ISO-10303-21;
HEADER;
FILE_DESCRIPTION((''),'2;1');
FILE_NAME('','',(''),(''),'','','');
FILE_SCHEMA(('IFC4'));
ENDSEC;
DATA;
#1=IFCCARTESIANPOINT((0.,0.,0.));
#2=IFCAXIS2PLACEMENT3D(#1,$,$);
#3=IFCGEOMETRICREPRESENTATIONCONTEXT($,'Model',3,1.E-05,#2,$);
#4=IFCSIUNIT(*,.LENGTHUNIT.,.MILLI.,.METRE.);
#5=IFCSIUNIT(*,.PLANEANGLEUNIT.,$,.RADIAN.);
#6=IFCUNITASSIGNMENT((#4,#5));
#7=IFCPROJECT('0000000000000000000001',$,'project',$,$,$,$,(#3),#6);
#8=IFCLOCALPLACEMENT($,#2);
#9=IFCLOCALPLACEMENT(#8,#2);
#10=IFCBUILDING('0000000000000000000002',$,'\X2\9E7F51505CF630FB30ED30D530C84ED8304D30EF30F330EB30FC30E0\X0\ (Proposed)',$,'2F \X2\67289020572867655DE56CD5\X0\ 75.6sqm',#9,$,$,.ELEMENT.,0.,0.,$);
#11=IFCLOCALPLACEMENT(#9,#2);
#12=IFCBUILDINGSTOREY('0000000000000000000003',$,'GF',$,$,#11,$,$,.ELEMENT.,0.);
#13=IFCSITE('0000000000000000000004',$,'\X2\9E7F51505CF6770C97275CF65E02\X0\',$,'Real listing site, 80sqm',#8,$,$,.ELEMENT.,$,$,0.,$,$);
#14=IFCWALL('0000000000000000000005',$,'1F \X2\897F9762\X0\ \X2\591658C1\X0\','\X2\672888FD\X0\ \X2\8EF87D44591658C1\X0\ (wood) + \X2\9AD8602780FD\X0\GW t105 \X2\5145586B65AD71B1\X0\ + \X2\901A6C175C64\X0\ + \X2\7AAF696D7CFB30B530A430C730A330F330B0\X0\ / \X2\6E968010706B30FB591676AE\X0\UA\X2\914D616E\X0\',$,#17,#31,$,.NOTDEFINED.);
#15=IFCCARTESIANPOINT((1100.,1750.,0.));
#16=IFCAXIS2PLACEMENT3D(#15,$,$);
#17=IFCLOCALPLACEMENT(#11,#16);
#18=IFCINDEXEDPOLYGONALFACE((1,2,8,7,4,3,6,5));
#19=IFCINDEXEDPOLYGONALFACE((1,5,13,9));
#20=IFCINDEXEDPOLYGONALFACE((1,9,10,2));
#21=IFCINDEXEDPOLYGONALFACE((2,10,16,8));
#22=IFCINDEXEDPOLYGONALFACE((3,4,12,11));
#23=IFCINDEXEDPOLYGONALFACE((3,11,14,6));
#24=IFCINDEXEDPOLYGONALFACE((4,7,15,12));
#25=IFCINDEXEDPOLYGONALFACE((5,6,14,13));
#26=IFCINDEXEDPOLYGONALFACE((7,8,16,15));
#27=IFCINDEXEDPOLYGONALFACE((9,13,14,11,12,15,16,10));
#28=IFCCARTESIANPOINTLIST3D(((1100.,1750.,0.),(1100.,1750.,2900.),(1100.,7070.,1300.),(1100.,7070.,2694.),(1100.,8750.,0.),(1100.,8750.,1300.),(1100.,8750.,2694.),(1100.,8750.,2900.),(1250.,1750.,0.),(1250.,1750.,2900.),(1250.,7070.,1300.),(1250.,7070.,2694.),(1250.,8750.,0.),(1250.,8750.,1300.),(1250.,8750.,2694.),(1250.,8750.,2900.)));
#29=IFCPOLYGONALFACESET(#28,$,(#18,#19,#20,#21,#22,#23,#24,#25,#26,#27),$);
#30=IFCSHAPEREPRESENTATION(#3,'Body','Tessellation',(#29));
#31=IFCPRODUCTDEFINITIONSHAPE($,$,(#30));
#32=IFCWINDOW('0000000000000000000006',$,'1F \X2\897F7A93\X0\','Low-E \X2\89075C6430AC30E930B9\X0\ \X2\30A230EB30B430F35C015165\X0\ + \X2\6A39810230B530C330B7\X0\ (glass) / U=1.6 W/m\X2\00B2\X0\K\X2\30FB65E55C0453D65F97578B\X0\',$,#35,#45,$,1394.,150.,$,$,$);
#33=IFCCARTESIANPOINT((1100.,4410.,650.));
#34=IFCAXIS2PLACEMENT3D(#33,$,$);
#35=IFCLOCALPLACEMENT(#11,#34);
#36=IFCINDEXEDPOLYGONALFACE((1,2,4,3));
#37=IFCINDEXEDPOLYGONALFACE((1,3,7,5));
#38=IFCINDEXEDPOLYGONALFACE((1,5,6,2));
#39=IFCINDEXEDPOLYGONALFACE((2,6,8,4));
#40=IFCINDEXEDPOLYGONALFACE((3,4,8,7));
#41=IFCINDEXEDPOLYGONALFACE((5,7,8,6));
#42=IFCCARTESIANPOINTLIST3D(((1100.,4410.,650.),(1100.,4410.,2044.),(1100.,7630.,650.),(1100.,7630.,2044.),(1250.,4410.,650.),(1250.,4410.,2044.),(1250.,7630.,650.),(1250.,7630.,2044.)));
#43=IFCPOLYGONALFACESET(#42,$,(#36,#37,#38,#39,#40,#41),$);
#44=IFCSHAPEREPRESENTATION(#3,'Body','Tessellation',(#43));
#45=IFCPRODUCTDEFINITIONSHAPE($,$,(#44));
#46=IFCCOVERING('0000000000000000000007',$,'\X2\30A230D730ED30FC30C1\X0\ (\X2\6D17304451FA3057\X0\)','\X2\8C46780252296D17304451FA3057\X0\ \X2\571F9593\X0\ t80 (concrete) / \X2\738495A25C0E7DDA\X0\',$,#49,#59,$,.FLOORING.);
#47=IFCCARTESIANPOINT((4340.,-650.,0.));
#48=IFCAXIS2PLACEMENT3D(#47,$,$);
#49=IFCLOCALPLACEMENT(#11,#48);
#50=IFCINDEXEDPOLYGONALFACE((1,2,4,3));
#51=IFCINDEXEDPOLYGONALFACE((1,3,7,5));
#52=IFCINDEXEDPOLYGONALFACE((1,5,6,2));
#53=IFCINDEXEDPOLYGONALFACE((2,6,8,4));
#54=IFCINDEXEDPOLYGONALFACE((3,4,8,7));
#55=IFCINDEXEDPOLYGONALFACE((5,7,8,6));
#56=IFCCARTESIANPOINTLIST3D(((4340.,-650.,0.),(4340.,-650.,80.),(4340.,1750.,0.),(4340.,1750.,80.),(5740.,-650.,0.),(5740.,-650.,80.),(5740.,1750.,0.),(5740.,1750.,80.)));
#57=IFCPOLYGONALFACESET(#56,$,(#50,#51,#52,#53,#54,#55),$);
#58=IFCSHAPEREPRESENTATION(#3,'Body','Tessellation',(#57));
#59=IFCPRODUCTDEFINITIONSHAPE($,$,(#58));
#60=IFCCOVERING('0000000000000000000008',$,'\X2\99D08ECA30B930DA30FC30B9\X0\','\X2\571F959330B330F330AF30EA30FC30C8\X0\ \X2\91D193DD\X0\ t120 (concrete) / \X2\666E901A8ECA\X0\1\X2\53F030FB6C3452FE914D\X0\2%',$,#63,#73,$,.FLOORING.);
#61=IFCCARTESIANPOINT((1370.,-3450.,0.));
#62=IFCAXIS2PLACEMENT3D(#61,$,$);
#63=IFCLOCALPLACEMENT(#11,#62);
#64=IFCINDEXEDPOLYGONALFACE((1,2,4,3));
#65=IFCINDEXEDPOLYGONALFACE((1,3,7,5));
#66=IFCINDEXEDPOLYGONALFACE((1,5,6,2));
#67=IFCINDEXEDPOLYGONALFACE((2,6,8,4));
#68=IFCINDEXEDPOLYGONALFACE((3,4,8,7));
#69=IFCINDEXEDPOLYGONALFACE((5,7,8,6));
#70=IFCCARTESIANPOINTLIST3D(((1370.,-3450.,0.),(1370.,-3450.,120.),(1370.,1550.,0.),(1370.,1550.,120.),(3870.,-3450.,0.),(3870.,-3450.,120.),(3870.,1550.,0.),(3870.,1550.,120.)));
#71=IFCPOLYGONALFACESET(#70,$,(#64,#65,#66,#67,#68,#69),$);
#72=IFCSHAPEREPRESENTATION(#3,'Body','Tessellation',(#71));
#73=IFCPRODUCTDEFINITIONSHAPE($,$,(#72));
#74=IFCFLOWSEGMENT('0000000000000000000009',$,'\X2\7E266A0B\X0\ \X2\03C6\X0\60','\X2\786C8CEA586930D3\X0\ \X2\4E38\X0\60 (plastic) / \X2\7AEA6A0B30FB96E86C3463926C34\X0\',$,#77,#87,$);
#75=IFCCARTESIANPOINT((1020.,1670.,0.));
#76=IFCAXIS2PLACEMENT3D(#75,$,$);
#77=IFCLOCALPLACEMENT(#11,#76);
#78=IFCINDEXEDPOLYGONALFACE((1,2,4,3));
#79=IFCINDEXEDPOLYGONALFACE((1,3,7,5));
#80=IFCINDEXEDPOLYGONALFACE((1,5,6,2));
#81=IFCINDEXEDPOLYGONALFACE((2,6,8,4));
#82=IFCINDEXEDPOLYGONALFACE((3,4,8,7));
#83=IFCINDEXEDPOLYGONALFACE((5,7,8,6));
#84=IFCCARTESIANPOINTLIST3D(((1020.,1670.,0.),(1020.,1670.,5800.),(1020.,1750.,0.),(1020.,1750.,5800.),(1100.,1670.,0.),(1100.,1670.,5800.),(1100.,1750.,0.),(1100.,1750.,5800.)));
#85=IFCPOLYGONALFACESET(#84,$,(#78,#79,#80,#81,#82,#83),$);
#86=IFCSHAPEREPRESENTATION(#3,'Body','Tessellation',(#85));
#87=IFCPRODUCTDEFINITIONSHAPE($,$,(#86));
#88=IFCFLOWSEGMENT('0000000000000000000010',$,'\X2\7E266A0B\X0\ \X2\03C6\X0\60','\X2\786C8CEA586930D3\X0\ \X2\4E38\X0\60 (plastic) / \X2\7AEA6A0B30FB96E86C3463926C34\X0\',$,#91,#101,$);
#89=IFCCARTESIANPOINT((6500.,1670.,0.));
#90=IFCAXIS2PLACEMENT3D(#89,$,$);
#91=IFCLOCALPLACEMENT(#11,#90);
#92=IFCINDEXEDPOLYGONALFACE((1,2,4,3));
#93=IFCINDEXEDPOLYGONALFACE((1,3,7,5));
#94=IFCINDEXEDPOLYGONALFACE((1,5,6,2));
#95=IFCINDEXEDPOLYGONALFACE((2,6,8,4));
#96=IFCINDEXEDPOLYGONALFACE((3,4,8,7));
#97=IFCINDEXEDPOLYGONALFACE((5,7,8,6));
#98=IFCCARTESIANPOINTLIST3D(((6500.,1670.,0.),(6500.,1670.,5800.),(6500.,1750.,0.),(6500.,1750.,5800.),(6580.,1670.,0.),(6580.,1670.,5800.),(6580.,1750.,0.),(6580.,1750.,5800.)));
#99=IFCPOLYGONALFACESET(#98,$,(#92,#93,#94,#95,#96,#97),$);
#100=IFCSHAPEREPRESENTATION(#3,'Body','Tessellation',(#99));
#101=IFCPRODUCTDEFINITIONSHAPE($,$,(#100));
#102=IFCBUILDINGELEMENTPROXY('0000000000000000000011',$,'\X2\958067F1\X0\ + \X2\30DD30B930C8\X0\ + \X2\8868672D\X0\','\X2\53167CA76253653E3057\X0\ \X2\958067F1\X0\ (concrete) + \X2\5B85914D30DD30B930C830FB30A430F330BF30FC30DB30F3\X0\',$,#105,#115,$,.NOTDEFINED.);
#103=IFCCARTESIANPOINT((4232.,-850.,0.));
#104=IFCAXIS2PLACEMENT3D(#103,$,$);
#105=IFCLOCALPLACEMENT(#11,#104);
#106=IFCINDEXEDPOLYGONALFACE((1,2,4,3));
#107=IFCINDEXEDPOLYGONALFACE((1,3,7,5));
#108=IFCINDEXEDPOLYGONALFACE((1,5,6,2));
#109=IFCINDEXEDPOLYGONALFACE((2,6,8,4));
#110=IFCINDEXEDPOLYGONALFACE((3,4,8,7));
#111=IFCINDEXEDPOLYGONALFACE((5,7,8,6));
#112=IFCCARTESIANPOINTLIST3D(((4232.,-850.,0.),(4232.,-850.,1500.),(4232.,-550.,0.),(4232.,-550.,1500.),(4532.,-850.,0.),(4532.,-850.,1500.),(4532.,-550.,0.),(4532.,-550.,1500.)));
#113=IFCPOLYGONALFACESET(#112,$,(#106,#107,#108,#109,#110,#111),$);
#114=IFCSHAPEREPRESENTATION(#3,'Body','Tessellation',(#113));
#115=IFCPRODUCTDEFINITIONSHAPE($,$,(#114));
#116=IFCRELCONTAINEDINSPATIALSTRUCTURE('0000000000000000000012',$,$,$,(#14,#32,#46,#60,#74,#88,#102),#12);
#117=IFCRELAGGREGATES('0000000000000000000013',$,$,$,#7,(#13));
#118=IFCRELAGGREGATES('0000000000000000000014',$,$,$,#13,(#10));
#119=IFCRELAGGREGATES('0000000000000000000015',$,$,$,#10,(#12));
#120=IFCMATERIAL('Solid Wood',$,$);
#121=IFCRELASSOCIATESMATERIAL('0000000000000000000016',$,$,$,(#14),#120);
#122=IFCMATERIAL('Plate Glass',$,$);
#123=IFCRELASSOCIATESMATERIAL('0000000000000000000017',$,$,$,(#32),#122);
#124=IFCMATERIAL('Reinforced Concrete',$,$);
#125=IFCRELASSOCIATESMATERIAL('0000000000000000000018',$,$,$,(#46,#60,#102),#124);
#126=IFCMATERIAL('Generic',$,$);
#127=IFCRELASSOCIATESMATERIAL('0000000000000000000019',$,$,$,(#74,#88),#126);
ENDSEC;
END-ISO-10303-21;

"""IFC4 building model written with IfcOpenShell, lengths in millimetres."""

from ifc_helpers import new_model, si_unit, frame, frame_2d, origin, place, context, project, spatial, rectangle, extrude, material, element, fill, save


model = new_model("IFC4")

# Units and contexts
model_context = context("Model", 3, precision=1e-05, world=origin())
ifc_project = project(units=[si_unit("LENGTHUNIT", "METRE", prefix="MILLI"), si_unit("PLANEANGLEUNIT", "RADIAN")], contexts=[model_context])

# Site, building, storey
site_placement = place(None, origin())
site = spatial("IfcSite", under=ifc_project, at=site_placement, Name="鹿児島県霧島市", ObjectType="Real listing site, 80sqm", CompositionType="ELEMENT", RefElevation=0.0)
building_placement = place(site_placement, origin())
building = spatial("IfcBuilding", under=site, at=building_placement, Name="鹿児島・ロフト付きワンルーム (Proposed)", ObjectType="2F 木造在来工法 75.6sqm", CompositionType="ELEMENT", ElevationOfRefHeight=0.0, ElevationOfTerrain=0.0)
storey_placement = place(building_placement, origin())
storey = spatial("IfcBuildingStorey", under=building, at=storey_placement, Name="GF", CompositionType="ELEMENT", Elevation=0.0)

# Shared definitions
ifc_material_1 = material(Name="Solid Wood")

# Shared definitions
ifc_material_2 = material(Name="Reinforced Concrete")

# Shared definitions
ifc_material_3 = material(Name="Plate Glass")

# Wall, opening, window
wall_1_placement = place(storey_placement, frame((1100.0, 1750.0, 0.0)))
wall_1 = element("IfcWall", 1, at=wall_1_placement, inside=storey, material=ifc_material_1, Name="1F 西面 外壁", Description="木製 軸組外壁 (wood) + 高性能GW t105 充填断熱 + 通気層 + 窯業系サイディング / 準耐火・外皮UA配慮", PredefinedType="NOTDEFINED", context=model_context, shape_type="SweptSolid", body=[
    extrude(rectangle(XDim=150.0, YDim=7000.0, at=frame_2d((75.0, 3500.0))), frame((1100.0, 1750.0, 0.0)), (0.0, 0.0, 1.0), 2900.0),
])
opening_1_placement = place(storey_placement, frame((1100.0, 4410.0, 650.0)))
opening_1 = element("IfcOpeningElement", 2, at=opening_1_placement, cuts=wall_1, PredefinedType="NOTDEFINED", context=model_context, shape_type="SweptSolid", body=[
    extrude(rectangle(XDim=150.0, YDim=3220.0, at=frame_2d((75.0, 1610.0))), frame((1100.0, 4410.0, 650.0)), (0.0, 0.0, 1.0), 1394.0),
])
window_1_placement = place(storey_placement, frame((1100.0, 4410.0, 650.0)))
window_1 = element("IfcWindow", 3, at=window_1_placement, inside=storey, material=ifc_material_3, Name="1F 西窓", Description="Low-E 複層ガラス アルゴン封入 + 樹脂サッシ (glass) / U=1.6 W/m²K・日射取得型", OverallHeight=1394.0, OverallWidth=150.0, context=model_context, shape_type="SweptSolid", body=[
    extrude(rectangle(XDim=150.0, YDim=3220.0, at=frame_2d((75.0, 1610.0))), frame((1100.0, 4410.0, 650.0)), (0.0, 0.0, 1.0), 1394.0),
])
fill(opening_1, window_1)

# Coverings
covering_1_placement = place(storey_placement, frame((4340.0, -650.0, 0.0)))
element("IfcCovering", 4, at=covering_1_placement, inside=storey, material=ifc_material_2, Name="アプローチ (洗い出し)", Description="豆砂利洗い出し 土間 t80 (concrete) / 玄関導線", PredefinedType="FLOORING", context=model_context, shape_type="SweptSolid", body=[
    extrude(rectangle(XDim=1400.0, YDim=2400.0, at=frame_2d((700.0, 1200.0))), frame((4340.0, -650.0, 0.0)), (0.0, 0.0, 1.0), 80.0),
])
covering_2_placement = place(storey_placement, frame((1370.0, -3450.0, 0.0)))
element("IfcCovering", 5, at=covering_2_placement, inside=storey, material=ifc_material_2, Name="駐車スペース", Description="土間コンクリート 金鏝 t120 (concrete) / 普通車1台・水勾配2%", PredefinedType="FLOORING", context=model_context, shape_type="SweptSolid", body=[
    extrude(rectangle(XDim=2500.0, YDim=5000.0, at=frame_2d((1250.0, 2500.0))), frame((1370.0, -3450.0, 0.0)), (0.0, 0.0, 1.0), 120.0),
])

# Flow segments
ifc_material_4 = material(Name="Generic")
flow_segment_1_placement = place(storey_placement, frame((1020.0, 1670.0, 0.0)))
element("IfcFlowSegment", 6, at=flow_segment_1_placement, inside=storey, material=ifc_material_4, Name="縦樋 φ60", Description="硬質塩ビ 丸60 (plastic) / 竪樋・雨水排水", context=model_context, shape_type="SweptSolid", body=[
    extrude(rectangle(XDim=80.0, YDim=80.0, at=frame_2d((40.0, 40.0))), frame((1020.0, 1670.0, 0.0)), (0.0, 0.0, 1.0), 5800.0),
])
flow_segment_2_placement = place(storey_placement, frame((6500.0, 1670.0, 0.0)))
element("IfcFlowSegment", 7, at=flow_segment_2_placement, inside=storey, material=ifc_material_4, Name="縦樋 φ60", Description="硬質塩ビ 丸60 (plastic) / 竪樋・雨水排水", context=model_context, shape_type="SweptSolid", body=[
    extrude(rectangle(XDim=80.0, YDim=80.0, at=frame_2d((40.0, 40.0))), frame((6500.0, 1670.0, 0.0)), (0.0, 0.0, 1.0), 5800.0),
])

# Building element proxy
proxy_placement = place(storey_placement, frame((4232.0, -850.0, 0.0)))
element("IfcBuildingElementProxy", 8, at=proxy_placement, inside=storey, material=ifc_material_2, Name="門柱 + ポスト + 表札", Description="化粧打放し 門柱 (concrete) + 宅配ポスト・インターホン", PredefinedType="NOTDEFINED", context=model_context, shape_type="SweptSolid", body=[
    extrude(rectangle(XDim=300.0, YDim=300.0, at=frame_2d((150.0, 150.0))), frame((4232.0, -850.0, 0.0)), (0.0, 0.0, 1.0), 1500.0),
])

save(model, "model.ifc")
